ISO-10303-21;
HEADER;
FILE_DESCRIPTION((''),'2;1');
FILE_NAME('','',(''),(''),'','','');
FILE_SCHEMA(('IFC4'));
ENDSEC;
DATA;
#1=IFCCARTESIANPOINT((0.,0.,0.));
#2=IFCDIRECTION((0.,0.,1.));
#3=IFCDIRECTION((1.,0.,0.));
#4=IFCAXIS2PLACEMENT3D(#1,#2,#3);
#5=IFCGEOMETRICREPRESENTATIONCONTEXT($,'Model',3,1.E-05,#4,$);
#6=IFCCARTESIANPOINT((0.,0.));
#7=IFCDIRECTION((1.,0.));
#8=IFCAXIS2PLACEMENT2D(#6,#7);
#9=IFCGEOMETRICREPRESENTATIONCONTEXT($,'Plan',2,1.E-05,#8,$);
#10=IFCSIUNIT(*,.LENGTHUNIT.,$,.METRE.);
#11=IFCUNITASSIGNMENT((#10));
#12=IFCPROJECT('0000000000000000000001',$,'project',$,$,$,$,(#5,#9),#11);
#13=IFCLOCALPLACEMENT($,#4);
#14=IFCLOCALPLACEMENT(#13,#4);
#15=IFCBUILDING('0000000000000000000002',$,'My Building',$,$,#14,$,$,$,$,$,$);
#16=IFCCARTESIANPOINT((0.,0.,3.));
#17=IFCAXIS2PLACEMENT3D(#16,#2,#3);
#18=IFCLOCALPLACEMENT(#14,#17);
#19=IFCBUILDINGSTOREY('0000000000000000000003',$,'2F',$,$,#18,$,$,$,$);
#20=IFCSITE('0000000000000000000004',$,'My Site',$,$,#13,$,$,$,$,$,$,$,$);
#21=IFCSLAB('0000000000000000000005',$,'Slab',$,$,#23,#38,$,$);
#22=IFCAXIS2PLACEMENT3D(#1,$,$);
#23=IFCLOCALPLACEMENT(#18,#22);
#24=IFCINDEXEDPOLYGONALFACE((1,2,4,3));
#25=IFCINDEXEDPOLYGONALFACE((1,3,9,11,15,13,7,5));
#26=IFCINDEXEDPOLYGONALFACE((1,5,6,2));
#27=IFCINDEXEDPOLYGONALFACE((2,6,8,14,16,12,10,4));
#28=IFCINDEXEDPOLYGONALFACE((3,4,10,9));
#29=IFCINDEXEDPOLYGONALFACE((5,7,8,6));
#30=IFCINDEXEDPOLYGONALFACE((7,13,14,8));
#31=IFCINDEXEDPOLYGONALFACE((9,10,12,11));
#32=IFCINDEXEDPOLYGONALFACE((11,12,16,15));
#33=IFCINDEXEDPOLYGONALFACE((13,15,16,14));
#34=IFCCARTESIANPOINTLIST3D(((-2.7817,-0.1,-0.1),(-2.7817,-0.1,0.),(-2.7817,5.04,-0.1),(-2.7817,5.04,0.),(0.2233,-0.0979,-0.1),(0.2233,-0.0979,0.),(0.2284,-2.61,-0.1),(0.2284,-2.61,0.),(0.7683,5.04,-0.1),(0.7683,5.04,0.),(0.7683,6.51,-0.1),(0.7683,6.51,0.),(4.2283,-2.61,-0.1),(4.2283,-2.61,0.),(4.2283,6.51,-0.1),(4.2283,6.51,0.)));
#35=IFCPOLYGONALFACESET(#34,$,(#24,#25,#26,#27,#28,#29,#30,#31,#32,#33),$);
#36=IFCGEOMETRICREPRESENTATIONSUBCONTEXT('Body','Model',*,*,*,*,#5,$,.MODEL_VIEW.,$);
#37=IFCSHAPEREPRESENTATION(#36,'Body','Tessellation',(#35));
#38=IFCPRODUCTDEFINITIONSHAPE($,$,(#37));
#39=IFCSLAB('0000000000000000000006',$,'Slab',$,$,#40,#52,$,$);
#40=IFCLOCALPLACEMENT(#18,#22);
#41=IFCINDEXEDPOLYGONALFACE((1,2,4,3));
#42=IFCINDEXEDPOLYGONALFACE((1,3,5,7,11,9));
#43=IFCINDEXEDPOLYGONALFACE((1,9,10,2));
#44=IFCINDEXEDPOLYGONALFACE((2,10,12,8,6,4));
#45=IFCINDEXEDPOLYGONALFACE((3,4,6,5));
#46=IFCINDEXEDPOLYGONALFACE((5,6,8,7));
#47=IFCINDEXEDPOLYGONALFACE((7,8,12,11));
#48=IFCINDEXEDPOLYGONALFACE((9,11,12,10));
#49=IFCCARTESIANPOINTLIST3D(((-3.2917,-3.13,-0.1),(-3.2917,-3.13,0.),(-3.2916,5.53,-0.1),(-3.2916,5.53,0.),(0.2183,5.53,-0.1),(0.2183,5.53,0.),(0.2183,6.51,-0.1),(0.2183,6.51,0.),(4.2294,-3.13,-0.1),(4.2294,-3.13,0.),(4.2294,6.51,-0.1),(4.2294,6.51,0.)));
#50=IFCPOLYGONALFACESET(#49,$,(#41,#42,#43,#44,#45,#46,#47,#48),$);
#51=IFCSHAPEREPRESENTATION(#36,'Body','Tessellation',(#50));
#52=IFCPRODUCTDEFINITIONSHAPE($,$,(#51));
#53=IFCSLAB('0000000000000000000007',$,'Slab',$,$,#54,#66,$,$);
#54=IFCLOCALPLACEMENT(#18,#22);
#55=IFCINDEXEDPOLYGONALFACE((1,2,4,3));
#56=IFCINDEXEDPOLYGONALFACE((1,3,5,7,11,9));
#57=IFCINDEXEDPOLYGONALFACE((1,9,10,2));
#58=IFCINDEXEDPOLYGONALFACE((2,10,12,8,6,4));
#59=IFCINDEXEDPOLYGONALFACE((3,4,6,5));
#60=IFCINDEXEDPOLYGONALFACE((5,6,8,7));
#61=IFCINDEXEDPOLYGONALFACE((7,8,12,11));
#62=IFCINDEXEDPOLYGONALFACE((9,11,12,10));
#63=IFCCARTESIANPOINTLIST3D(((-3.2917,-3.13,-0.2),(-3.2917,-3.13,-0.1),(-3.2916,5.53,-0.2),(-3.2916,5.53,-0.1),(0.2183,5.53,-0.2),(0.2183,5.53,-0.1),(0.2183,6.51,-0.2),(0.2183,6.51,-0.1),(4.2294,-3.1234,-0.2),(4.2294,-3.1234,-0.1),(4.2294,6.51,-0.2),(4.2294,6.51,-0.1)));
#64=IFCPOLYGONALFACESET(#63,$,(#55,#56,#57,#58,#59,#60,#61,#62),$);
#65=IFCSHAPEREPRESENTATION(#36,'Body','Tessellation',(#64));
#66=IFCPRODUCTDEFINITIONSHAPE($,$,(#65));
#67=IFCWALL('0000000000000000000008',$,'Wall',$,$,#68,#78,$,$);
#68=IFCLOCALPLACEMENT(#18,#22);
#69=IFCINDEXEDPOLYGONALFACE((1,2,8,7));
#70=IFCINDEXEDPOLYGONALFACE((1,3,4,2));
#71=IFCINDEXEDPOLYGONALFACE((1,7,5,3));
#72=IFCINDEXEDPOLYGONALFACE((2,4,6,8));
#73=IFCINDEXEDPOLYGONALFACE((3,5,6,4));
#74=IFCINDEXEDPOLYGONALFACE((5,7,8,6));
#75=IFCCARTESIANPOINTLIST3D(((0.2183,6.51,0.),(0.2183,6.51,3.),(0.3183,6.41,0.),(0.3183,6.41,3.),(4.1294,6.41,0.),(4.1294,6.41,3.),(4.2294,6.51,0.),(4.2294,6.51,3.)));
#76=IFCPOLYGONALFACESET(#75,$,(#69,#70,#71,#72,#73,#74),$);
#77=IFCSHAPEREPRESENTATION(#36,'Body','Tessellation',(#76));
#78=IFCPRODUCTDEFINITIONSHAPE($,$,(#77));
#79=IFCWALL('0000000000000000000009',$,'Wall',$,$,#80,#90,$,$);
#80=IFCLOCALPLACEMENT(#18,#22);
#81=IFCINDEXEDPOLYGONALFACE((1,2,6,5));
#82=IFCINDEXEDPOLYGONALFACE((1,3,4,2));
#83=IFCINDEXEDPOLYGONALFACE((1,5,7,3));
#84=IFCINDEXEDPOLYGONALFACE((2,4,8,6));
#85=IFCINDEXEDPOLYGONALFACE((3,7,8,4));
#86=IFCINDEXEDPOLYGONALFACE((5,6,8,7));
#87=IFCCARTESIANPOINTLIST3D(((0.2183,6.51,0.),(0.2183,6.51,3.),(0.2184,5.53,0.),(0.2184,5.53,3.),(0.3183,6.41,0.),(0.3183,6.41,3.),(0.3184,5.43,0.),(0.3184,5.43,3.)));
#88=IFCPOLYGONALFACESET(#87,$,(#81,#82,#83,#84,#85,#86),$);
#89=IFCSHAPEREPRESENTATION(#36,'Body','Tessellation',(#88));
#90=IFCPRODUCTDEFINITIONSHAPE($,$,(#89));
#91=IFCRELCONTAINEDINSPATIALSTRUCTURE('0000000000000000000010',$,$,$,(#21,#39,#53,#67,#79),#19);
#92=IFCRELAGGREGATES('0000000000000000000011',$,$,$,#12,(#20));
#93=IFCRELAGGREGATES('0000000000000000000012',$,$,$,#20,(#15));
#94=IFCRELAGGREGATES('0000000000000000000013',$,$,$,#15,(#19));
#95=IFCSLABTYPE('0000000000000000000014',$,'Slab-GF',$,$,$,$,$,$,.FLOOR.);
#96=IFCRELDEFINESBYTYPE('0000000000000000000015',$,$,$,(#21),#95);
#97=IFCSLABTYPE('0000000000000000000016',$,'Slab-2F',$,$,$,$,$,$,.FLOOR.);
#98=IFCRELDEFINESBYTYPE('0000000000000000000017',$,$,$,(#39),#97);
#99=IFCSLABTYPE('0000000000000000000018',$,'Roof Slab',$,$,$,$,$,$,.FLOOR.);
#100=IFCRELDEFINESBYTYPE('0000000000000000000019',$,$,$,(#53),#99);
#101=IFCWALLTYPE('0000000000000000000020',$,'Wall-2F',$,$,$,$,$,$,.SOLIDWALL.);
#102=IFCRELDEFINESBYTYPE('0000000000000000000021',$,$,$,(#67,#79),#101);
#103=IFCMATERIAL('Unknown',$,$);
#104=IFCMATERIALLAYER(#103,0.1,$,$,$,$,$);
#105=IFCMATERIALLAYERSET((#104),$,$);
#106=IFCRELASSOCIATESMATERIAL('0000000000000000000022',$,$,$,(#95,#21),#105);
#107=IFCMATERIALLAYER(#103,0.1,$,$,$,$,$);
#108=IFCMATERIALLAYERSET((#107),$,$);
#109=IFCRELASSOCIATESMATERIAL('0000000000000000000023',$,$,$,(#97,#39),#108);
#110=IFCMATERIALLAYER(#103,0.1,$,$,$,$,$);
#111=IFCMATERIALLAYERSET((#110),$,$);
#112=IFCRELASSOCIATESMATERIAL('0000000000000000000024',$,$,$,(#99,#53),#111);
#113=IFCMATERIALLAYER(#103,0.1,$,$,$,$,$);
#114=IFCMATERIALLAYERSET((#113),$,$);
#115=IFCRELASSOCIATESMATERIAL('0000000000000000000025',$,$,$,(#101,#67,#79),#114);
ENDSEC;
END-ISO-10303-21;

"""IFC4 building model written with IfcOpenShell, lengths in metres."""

from ifc_helpers import new_model, si_unit, frame, origin_with_axes, origin_2d_with_axis, place, context, subcontext, project, spatial, line, indexed_curve, outline, extrude, material, layer, layer_set, layer_usage, type_object, element, save


model = new_model("IFC4")

# Units and contexts
model_context = context("Model", 3, precision=1e-05, world=origin_with_axes())
plan_context = context("Plan", 2, precision=1e-05, world=origin_2d_with_axis())
body_context_1 = subcontext(model_context, "Body", "Model", "MODEL_VIEW")
ifc_project = project(units=[si_unit("LENGTHUNIT", "METRE")], contexts=[model_context, plan_context])

# Site, building, storey
site_placement = place(None, origin_with_axes())
site = spatial("IfcSite", under=ifc_project, at=site_placement, Name="My Site")
building_placement = place(site_placement, origin_with_axes())
building = spatial("IfcBuilding", under=site, at=building_placement, Name="My Building")
storey_placement = place(building_placement, frame((0.0, 0.0, 3.0), z_axis=(0.0, 0.0, 1.0), x_axis=(1.0, 0.0, 0.0)))
storey = spatial("IfcBuildingStorey", under=building, at=storey_placement, Name="2F")

# Slabs
ifc_material = material(Name="Unknown")
ifc_layer_1 = layer(ifc_material, 0.1)
ifc_layer_set_1 = layer_set([ifc_layer_1])
ifc_layer_usage_1 = layer_usage(ifc_layer_set_1, "AXIS3", "POSITIVE", -0.1)
slab_type_1 = type_object("IfcSlabType", Name="Slab-GF", PredefinedType="FLOOR", material=ifc_layer_set_1)
slab_1_placement = place(storey_placement, frame((4.2283, -2.61, 0.0), z_axis=(0.0, 0.0, 1.0), x_axis=(1.0, 0.0, 0.0)))
element("IfcSlab", 1, at=slab_1_placement, inside=storey, type_object=slab_type_1, material=ifc_layer_usage_1, Name="Slab", context=body_context_1, shape_type="SweptSolid", body=[
    extrude(outline(indexed_curve([(0.0, 0.0), (0.0, 9.12), (-3.46, 9.12), (-3.46, 7.65), (-7.01, 7.65), (-7.01, 2.51), (-4.0051, 2.5122), (-4.0, 0.0), (0.0, 0.0)])), frame((0.0, 0.0, -0.1), z_axis=(0.0, 0.0, 1.0), x_axis=(1.0, 0.0, 0.0)), (0.0, 0.0, 1.0), 0.1),
])
ifc_layer_2 = layer(ifc_material, 0.1)
ifc_layer_set_2 = layer_set([ifc_layer_2])
ifc_layer_usage_2 = layer_usage(ifc_layer_set_2, "AXIS3", "POSITIVE", -0.1)
slab_type_2 = type_object("IfcSlabType", Name="Slab-2F", PredefinedType="FLOOR", material=ifc_layer_set_2)
slab_2_placement = place(storey_placement, frame((4.2294, 6.51, 0.0), z_axis=(0.0, 0.0, 1.0), x_axis=(1.0, 0.0, 0.0)))
element("IfcSlab", 2, at=slab_2_placement, inside=storey, type_object=slab_type_2, material=ifc_layer_usage_2, Name="Slab", context=body_context_1, shape_type="SweptSolid", body=[
    extrude(outline(indexed_curve([(0.0, 0.0), (-4.0111, 0.0), (-4.0111, -0.98), (-7.5211, -0.98), (-7.5211, -9.64), (0.0, -9.64), (0.0, 0.0)])), frame((0.0, 0.0, -0.1), z_axis=(0.0, 0.0, 1.0), x_axis=(1.0, 0.0, 0.0)), (0.0, 0.0, 1.0), 0.1),
])
ifc_layer_3 = layer(ifc_material, 0.1)
ifc_layer_set_3 = layer_set([ifc_layer_3])
ifc_layer_usage_3 = layer_usage(ifc_layer_set_3, "AXIS3", "NEGATIVE", -0.1)
slab_type_3 = type_object("IfcSlabType", Name="Roof Slab", PredefinedType="FLOOR", material=ifc_layer_set_3)
slab_3_placement = place(storey_placement, frame((4.2294, 6.51, 0.0), z_axis=(0.0, 0.0, 1.0), x_axis=(1.0, 0.0, 0.0)))
element("IfcSlab", 3, at=slab_3_placement, inside=storey, type_object=slab_type_3, material=ifc_layer_usage_3, Name="Slab", context=body_context_1, shape_type="SweptSolid", body=[
    extrude(outline(indexed_curve([(0.0, 0.0), (-4.0111, 0.0), (-4.0111, -0.98), (-7.5211, -0.98), (-7.5211, -9.64), (0.0, -9.6334), (0.0, 0.0)])), frame((0.0, 0.0, -0.1), z_axis=(0.0, 0.0, 1.0), x_axis=(1.0, 0.0, 0.0)), (0.0, 0.0, -1.0), 0.1),
])

# Walls
ifc_layer_4 = layer(ifc_material, 0.1)
ifc_layer_set_4 = layer_set([ifc_layer_4])
ifc_layer_usage_4 = layer_usage(ifc_layer_set_4, "AXIS2", "POSITIVE", 0.0)
wall_type = type_object("IfcWallType", Name="Wall-2F", PredefinedType="SOLIDWALL", material=ifc_layer_set_4)
wall_1_placement = place(storey_placement, frame((4.2294, 6.51, 0.0), z_axis=(0.0, 0.0, 1.0), x_axis=(-1.0, 0.0, 0.0)))
element("IfcWall", 4, at=wall_1_placement, inside=storey, type_object=wall_type, material=ifc_layer_usage_4, Name="Wall", context=body_context_1, shape_type="SweptSolid", body=[
    extrude(outline(indexed_curve([(0.0, 0.0), (0.1, 0.1), (3.9111, 0.1), (4.0111, 0.0)], segments=[line(1, 2, 3, 4, 1)])), origin_with_axes(), (0.0, 0.0, 1.0), 3.0),
])
ifc_layer_usage_5 = layer_usage(ifc_layer_set_4, "AXIS2", "POSITIVE", 0.0)
wall_2_placement = place(storey_placement, frame((0.2183, 6.51, 0.0), z_axis=(0.0, 0.0, 1.0), x_axis=(0.0, -1.0, 0.0)))
element("IfcWall", 5, at=wall_2_placement, inside=storey, type_object=wall_type, material=ifc_layer_usage_5, Name="Wall", context=body_context_1, shape_type="SweptSolid", body=[
    extrude(outline(indexed_curve([(0.0, 0.0), (0.1, 0.1), (1.08, 0.1), (0.98, 0.0)], segments=[line(1, 2, 3, 4, 1)])), origin_with_axes(), (0.0, 0.0, 1.0), 3.0),
])

save(model, "model.ifc")
